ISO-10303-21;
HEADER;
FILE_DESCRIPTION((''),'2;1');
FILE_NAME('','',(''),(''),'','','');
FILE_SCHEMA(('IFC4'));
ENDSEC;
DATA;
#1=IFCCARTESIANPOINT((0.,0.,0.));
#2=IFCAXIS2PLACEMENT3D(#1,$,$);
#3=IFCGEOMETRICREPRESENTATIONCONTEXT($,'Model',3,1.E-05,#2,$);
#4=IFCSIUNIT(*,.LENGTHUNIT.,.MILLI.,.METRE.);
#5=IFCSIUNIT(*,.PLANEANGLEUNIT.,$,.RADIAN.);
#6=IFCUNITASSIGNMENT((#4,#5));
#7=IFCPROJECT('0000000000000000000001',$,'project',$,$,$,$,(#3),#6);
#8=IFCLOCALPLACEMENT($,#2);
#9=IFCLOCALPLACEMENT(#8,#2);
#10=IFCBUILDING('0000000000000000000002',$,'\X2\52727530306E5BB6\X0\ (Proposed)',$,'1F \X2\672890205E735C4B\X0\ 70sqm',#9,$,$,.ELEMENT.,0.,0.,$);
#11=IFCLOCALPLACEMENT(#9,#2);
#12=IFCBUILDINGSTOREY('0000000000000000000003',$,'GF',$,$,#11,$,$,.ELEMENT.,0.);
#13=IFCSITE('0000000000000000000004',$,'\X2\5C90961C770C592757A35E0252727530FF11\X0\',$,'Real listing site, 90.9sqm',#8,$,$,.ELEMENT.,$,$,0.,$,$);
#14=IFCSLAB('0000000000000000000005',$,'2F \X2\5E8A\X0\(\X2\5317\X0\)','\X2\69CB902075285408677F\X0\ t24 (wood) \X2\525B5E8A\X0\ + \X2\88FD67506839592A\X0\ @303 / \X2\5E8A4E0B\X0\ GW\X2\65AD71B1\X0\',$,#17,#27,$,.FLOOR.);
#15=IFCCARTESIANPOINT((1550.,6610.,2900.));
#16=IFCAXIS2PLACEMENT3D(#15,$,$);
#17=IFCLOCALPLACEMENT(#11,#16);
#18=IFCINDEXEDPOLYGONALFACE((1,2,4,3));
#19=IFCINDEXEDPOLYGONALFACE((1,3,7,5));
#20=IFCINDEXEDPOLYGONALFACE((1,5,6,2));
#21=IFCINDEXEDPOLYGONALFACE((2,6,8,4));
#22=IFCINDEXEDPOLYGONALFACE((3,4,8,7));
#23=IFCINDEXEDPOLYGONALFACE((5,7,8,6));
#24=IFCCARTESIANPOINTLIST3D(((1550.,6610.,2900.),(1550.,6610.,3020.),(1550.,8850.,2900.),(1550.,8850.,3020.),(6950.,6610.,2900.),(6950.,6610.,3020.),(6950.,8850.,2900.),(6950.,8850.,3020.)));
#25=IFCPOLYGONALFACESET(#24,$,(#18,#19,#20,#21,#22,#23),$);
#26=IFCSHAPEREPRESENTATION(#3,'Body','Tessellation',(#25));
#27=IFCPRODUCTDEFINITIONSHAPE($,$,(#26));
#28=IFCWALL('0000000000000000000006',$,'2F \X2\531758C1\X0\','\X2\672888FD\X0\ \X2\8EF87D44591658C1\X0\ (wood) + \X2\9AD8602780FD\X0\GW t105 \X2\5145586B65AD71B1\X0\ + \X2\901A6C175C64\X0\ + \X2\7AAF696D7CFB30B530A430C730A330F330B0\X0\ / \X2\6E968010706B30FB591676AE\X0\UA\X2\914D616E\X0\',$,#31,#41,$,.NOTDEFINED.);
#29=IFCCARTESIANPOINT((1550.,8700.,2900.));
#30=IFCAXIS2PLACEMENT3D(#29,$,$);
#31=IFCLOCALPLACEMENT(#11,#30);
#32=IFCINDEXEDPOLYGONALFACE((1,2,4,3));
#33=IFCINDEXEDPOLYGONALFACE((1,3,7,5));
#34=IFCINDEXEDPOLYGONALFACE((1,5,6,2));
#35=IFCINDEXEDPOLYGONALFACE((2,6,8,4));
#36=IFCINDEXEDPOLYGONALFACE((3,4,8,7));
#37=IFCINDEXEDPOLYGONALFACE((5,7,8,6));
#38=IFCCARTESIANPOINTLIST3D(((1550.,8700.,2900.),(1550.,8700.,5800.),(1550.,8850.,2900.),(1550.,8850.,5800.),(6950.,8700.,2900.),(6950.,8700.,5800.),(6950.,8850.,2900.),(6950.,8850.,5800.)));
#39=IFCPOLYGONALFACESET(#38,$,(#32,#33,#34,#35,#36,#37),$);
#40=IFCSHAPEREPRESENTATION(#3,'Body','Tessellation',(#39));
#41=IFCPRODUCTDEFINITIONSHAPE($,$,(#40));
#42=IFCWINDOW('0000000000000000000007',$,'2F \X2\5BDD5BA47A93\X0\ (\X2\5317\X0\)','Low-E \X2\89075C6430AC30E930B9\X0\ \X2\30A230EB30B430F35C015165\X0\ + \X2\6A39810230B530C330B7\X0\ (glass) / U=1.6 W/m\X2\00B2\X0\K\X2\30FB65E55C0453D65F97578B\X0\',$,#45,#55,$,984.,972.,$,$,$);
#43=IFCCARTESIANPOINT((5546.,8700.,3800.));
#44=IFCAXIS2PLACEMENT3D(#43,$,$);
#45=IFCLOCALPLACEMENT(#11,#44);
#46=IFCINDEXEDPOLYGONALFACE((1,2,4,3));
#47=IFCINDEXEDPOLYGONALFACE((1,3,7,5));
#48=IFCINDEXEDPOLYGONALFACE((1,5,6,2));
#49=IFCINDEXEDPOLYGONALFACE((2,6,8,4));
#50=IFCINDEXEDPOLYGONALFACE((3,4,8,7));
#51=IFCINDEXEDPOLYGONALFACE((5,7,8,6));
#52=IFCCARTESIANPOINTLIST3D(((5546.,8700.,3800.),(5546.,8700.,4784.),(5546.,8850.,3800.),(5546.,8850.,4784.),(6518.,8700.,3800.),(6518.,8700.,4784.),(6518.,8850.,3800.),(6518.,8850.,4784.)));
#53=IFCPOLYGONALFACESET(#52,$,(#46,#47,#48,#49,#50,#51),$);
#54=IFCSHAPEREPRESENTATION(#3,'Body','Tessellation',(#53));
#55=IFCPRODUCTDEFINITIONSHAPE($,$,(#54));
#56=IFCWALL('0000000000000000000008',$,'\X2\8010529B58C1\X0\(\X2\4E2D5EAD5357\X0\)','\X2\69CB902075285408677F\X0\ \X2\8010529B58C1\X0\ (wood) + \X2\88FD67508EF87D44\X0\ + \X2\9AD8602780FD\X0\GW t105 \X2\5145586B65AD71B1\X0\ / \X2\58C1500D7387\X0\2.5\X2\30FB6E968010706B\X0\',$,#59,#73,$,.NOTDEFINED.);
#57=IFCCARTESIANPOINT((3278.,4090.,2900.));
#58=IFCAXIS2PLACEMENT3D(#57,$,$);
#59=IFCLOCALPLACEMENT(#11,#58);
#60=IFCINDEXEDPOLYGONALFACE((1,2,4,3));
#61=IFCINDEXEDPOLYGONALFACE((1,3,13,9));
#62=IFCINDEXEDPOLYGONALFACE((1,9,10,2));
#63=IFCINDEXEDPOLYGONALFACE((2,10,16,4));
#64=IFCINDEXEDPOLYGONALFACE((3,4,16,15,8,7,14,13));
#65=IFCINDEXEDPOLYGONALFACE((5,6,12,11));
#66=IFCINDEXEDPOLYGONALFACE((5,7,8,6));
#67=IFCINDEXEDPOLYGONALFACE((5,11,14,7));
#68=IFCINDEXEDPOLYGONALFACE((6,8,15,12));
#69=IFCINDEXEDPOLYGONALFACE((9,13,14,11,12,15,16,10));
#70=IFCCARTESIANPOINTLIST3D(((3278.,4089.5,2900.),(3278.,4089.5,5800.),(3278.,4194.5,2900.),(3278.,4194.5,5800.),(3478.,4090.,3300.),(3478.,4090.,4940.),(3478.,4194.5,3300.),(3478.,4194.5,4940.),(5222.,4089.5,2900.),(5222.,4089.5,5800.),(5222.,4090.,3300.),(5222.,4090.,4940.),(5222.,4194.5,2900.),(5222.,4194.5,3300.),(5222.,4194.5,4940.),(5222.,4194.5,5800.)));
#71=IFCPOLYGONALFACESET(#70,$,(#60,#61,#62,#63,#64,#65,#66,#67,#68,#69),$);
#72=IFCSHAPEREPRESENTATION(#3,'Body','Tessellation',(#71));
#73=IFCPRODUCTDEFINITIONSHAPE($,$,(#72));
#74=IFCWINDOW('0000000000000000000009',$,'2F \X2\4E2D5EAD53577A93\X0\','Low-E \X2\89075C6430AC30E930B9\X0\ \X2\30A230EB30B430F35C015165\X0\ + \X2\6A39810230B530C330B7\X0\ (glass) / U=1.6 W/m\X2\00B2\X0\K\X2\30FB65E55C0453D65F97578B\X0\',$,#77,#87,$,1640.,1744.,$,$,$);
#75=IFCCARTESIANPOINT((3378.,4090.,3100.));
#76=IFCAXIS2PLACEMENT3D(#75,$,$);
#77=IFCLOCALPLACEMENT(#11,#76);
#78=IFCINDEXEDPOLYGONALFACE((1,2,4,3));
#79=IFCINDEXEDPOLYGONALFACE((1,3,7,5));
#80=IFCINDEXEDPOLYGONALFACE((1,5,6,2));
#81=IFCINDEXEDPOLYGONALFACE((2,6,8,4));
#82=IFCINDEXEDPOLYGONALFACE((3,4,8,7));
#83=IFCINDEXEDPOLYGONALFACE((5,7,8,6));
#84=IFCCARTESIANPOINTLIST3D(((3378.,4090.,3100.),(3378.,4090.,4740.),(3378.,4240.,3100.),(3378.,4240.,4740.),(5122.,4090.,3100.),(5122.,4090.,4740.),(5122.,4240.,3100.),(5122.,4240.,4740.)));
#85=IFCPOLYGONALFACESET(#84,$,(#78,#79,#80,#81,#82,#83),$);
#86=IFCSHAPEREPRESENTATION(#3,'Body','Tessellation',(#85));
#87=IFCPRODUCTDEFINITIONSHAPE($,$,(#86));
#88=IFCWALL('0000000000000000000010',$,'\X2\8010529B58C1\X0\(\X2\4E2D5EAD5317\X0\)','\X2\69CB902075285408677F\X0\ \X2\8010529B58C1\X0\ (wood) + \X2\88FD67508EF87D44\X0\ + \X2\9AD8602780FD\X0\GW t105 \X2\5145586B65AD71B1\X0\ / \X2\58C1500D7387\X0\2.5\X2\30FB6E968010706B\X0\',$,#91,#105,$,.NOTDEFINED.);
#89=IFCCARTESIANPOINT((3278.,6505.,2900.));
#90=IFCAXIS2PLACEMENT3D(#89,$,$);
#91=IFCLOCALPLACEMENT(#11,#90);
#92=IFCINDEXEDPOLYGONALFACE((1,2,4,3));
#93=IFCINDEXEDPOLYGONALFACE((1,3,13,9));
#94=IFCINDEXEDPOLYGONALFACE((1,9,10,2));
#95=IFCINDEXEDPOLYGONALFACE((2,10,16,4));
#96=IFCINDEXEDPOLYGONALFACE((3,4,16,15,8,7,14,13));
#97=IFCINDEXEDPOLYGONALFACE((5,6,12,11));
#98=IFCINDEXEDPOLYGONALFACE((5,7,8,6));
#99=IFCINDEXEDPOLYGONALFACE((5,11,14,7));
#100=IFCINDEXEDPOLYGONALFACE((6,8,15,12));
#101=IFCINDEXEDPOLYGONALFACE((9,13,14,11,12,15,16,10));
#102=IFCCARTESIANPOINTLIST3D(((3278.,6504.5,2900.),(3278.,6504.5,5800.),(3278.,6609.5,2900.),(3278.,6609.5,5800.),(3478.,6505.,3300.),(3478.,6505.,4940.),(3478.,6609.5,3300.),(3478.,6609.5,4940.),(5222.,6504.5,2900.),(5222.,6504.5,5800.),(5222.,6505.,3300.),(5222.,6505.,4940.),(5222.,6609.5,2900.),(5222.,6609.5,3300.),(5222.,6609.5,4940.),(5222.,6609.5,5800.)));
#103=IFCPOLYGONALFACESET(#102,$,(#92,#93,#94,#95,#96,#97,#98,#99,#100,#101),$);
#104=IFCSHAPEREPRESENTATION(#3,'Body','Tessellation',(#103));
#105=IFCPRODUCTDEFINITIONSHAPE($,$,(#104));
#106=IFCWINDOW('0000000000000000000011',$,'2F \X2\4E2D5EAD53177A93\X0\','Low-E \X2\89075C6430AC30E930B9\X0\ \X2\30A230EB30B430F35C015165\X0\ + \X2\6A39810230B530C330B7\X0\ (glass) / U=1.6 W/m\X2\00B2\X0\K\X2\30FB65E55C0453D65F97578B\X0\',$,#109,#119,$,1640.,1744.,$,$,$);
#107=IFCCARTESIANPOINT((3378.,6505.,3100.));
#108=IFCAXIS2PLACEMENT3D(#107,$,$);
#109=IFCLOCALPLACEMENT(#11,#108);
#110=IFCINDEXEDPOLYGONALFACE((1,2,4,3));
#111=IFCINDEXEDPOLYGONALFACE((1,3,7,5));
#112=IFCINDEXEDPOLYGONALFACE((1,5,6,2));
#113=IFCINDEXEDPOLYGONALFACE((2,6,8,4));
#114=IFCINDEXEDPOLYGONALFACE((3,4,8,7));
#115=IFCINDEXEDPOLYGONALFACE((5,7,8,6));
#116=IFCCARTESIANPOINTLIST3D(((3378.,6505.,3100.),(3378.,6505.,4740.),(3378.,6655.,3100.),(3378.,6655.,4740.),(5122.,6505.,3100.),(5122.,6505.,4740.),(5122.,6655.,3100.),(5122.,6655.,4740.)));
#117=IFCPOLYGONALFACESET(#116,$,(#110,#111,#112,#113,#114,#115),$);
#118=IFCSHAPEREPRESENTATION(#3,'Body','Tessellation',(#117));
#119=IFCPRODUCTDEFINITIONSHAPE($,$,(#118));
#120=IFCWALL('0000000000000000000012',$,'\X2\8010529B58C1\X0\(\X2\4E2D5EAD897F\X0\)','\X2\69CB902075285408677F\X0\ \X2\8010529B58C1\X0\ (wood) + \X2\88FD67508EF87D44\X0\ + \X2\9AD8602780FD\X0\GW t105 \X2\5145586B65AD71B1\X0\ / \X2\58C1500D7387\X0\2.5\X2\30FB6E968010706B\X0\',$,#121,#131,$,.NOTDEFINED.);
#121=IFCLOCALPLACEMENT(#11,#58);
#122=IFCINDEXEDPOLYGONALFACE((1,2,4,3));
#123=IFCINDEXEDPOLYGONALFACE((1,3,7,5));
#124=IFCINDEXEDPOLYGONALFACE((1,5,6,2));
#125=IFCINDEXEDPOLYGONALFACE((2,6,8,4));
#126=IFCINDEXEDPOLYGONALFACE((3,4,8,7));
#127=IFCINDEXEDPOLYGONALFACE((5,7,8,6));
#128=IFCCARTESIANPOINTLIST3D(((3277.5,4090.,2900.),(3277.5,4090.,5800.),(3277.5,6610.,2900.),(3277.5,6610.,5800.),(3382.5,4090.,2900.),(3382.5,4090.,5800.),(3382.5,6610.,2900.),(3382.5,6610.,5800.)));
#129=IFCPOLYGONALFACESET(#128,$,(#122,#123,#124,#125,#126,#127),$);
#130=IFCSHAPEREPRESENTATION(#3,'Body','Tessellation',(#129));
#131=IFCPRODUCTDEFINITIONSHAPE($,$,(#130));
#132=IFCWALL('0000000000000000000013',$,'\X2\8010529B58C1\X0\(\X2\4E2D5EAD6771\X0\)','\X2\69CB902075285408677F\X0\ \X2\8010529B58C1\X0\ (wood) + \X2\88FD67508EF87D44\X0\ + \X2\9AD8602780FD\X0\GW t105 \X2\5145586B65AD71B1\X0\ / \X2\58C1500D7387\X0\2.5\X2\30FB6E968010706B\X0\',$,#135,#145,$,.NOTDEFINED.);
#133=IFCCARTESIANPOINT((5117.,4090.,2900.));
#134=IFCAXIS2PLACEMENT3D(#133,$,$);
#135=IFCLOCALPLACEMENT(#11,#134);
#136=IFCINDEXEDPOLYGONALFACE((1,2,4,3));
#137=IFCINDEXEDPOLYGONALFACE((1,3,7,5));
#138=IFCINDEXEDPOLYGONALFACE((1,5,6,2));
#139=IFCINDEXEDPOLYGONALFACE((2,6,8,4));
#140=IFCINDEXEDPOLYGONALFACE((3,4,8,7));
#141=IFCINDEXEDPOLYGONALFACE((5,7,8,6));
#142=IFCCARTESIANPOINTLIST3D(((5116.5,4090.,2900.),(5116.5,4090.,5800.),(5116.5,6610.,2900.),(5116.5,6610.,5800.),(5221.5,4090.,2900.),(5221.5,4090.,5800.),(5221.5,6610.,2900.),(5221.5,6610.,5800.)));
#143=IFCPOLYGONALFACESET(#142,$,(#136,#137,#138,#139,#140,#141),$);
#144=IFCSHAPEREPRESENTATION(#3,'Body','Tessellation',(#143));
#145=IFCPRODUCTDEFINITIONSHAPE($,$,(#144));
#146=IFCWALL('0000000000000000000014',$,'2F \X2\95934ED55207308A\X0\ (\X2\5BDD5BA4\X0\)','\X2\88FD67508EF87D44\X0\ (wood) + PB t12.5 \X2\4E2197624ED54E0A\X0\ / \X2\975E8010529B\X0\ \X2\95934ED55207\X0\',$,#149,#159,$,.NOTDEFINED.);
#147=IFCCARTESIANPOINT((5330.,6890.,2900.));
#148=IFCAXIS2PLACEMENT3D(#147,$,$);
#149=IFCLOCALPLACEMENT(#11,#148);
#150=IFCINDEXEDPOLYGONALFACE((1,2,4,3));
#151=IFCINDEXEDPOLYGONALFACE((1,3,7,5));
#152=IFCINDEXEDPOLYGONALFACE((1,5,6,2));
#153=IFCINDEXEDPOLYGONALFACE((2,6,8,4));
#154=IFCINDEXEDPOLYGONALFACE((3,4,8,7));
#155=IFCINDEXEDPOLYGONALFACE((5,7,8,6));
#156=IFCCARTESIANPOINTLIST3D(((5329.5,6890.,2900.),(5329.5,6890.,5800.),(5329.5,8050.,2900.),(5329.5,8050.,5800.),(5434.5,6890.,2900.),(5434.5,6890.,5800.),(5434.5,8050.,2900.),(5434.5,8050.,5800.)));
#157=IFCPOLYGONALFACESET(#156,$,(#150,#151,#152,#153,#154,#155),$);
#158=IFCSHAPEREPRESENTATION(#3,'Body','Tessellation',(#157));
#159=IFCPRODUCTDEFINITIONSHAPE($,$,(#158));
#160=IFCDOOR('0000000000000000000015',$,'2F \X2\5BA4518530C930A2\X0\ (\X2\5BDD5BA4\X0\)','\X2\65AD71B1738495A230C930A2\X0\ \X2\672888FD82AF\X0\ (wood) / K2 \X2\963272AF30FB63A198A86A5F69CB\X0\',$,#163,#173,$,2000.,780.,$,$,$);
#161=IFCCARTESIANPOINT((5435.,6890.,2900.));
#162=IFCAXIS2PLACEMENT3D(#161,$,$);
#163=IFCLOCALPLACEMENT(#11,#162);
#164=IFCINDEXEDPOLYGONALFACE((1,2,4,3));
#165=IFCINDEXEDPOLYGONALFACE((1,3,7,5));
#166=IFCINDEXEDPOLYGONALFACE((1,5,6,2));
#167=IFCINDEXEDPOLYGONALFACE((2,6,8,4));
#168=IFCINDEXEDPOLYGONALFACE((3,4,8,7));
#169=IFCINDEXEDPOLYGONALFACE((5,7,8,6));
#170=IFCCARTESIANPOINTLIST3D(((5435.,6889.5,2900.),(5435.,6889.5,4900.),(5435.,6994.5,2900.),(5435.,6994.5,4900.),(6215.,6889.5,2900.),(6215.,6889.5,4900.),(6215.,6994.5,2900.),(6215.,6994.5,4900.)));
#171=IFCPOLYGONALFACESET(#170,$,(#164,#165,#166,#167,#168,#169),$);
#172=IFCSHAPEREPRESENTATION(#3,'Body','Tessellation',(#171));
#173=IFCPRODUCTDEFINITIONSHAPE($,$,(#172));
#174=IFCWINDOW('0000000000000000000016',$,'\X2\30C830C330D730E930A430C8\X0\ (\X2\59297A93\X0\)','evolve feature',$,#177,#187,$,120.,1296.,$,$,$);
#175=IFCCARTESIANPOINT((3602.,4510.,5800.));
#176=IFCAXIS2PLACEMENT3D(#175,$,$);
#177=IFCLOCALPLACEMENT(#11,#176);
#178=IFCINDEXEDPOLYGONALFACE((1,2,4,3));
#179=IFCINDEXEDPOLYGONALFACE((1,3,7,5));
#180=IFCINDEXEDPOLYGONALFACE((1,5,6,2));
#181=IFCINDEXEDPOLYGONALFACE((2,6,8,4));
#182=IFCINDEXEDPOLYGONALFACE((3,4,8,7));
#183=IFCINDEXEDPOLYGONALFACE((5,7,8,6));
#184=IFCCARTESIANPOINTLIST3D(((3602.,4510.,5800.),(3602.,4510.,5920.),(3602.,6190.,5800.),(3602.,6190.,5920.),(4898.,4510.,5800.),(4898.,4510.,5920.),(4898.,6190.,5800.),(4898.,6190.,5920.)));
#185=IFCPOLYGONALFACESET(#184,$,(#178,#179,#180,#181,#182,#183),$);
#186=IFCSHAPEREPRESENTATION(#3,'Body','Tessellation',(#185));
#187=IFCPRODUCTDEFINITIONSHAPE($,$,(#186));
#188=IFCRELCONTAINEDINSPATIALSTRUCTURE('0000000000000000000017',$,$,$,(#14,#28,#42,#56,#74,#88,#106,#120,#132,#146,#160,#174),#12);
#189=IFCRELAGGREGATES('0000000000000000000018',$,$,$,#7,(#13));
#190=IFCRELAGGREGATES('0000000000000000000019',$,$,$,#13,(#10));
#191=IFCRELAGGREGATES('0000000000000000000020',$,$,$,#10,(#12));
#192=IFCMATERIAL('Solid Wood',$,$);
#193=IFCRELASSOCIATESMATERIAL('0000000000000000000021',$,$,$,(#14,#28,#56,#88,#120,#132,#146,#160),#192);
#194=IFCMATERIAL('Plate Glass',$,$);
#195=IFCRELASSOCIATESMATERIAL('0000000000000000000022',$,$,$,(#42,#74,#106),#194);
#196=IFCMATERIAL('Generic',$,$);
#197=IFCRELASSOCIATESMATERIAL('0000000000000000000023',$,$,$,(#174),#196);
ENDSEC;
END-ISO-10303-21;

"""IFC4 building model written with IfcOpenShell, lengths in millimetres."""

from ifc_helpers import new_model, si_unit, frame, frame_2d, origin, place, context, project, spatial, rectangle, extrude, material, element, fill, save


model = new_model("IFC4")

# Units and contexts
model_context = context("Model", 3, precision=1e-05, world=origin())
ifc_project = project(units=[si_unit("LENGTHUNIT", "METRE", prefix="MILLI"), si_unit("PLANEANGLEUNIT", "RADIAN")], contexts=[model_context])

# Site, building, storey
site_placement = place(None, origin())
site = spatial("IfcSite", under=ifc_project, at=site_placement, Name="岐阜県大垣市割田１", ObjectType="Real listing site, 90.9sqm", CompositionType="ELEMENT", RefElevation=0.0)
building_placement = place(site_placement, origin())
building = spatial("IfcBuilding", under=site, at=building_placement, Name="割田の家 (Proposed)", ObjectType="1F 木造平屋 70sqm", CompositionType="ELEMENT", ElevationOfRefHeight=0.0, ElevationOfTerrain=0.0)
storey_placement = place(building_placement, origin())
storey = spatial("IfcBuildingStorey", under=building, at=storey_placement, Name="GF", CompositionType="ELEMENT", Elevation=0.0)

# Slab
ifc_material_1 = material(Name="Solid Wood")
slab_placement = place(storey_placement, frame((1550.0, 6610.0, 2900.0)))
element("IfcSlab", 1, at=slab_placement, inside=storey, material=ifc_material_1, Name="2F 床(北)", Description="構造用合板 t24 (wood) 剛床 + 製材根太 @303 / 床下 GW断熱", PredefinedType="FLOOR", context=model_context, shape_type="SweptSolid", body=[
    extrude(rectangle(XDim=5400.0, YDim=2240.0, at=frame_2d((2700.0, 1120.0))), frame((1550.0, 6610.0, 2900.0)), (0.0, 0.0, 1.0), 120.0),
])

# Walls, openings, windows
wall_1_placement = place(storey_placement, frame((1550.0, 8700.0, 2900.0)))
wall_1 = element("IfcWall", 2, at=wall_1_placement, inside=storey, material=ifc_material_1, Name="2F 北壁", Description="木製 軸組外壁 (wood) + 高性能GW t105 充填断熱 + 通気層 + 窯業系サイディング / 準耐火・外皮UA配慮", PredefinedType="NOTDEFINED", context=model_context, shape_type="SweptSolid", body=[
    extrude(rectangle(XDim=5400.0, YDim=150.0, at=frame_2d((2700.0, 75.0))), frame((1550.0, 8700.0, 2900.0)), (0.0, 0.0, 1.0), 2900.0),
])
opening_1_placement = place(storey_placement, frame((5546.0, 8700.0, 3800.0)))
opening_1 = element("IfcOpeningElement", 3, at=opening_1_placement, cuts=wall_1, PredefinedType="NOTDEFINED", context=model_context, shape_type="SweptSolid", body=[
    extrude(rectangle(XDim=972.0, YDim=150.0, at=frame_2d((486.0, 75.0))), frame((5546.0, 8700.0, 3800.0)), (0.0, 0.0, 1.0), 984.0),
])
ifc_material_2 = material(Name="Plate Glass")
window_1_placement = place(storey_placement, frame((5546.0, 8700.0, 3800.0)))
window_1 = element("IfcWindow", 4, at=window_1_placement, inside=storey, material=ifc_material_2, Name="2F 寝室窓 (北)", Description="Low-E 複層ガラス アルゴン封入 + 樹脂サッシ (glass) / U=1.6 W/m²K・日射取得型", OverallHeight=984.0, OverallWidth=972.0, context=model_context, shape_type="SweptSolid", body=[
    extrude(rectangle(XDim=972.0, YDim=150.0, at=frame_2d((486.0, 75.0))), frame((5546.0, 8700.0, 3800.0)), (0.0, 0.0, 1.0), 984.0),
])
fill(opening_1, window_1)
wall_2_placement = place(storey_placement, frame((3278.0, 4090.0, 2900.0)))
wall_2 = element("IfcWall", 5, at=wall_2_placement, inside=storey, material=ifc_material_1, Name="耐力壁(中庭南)", Description="構造用合板 耐力壁 (wood) + 製材軸組 + 高性能GW t105 充填断熱 / 壁倍率2.5・準耐火", PredefinedType="NOTDEFINED", context=model_context, shape_type="SweptSolid", body=[
    extrude(rectangle(XDim=1944.0, YDim=105.0, at=frame_2d((972.0, 52.0))), frame((3278.0, 4090.0, 2900.0)), (0.0, 0.0, 1.0), 2900.0),
])
opening_2_placement = place(storey_placement, frame((3378.0, 4090.0, 3100.0)))
opening_2 = element("IfcOpeningElement", 6, at=opening_2_placement, cuts=wall_2, PredefinedType="NOTDEFINED", context=model_context, shape_type="SweptSolid", body=[
    extrude(rectangle(XDim=1744.0, YDim=150.0, at=frame_2d((872.0, 75.0))), frame((3378.0, 4090.0, 3100.0)), (0.0, 0.0, 1.0), 1640.0),
])
window_2_placement = place(storey_placement, frame((3378.0, 4090.0, 3100.0)))
window_2 = element("IfcWindow", 7, at=window_2_placement, inside=storey, material=ifc_material_2, Name="2F 中庭南窓", Description="Low-E 複層ガラス アルゴン封入 + 樹脂サッシ (glass) / U=1.6 W/m²K・日射取得型", OverallHeight=1640.0, OverallWidth=1744.0, context=model_context, shape_type="SweptSolid", body=[
    extrude(rectangle(XDim=1744.0, YDim=150.0, at=frame_2d((872.0, 75.0))), frame((3378.0, 4090.0, 3100.0)), (0.0, 0.0, 1.0), 1640.0),
])
fill(opening_2, window_2)
wall_3_placement = place(storey_placement, frame((3278.0, 6505.0, 2900.0)))
wall_3 = element("IfcWall", 8, at=wall_3_placement, inside=storey, material=ifc_material_1, Name="耐力壁(中庭北)", Description="構造用合板 耐力壁 (wood) + 製材軸組 + 高性能GW t105 充填断熱 / 壁倍率2.5・準耐火", PredefinedType="NOTDEFINED", context=model_context, shape_type="SweptSolid", body=[
    extrude(rectangle(XDim=1944.0, YDim=105.0, at=frame_2d((972.0, 52.0))), frame((3278.0, 6505.0, 2900.0)), (0.0, 0.0, 1.0), 2900.0),
])
opening_3_placement = place(storey_placement, frame((3378.0, 6505.0, 3100.0)))
opening_3 = element("IfcOpeningElement", 9, at=opening_3_placement, cuts=wall_3, PredefinedType="NOTDEFINED", context=model_context, shape_type="SweptSolid", body=[
    extrude(rectangle(XDim=1744.0, YDim=150.0, at=frame_2d((872.0, 75.0))), frame((3378.0, 6505.0, 3100.0)), (0.0, 0.0, 1.0), 1640.0),
])
window_3_placement = place(storey_placement, frame((3378.0, 6505.0, 3100.0)))
window_3 = element("IfcWindow", 10, at=window_3_placement, inside=storey, material=ifc_material_2, Name="2F 中庭北窓", Description="Low-E 複層ガラス アルゴン封入 + 樹脂サッシ (glass) / U=1.6 W/m²K・日射取得型", OverallHeight=1640.0, OverallWidth=1744.0, context=model_context, shape_type="SweptSolid", body=[
    extrude(rectangle(XDim=1744.0, YDim=150.0, at=frame_2d((872.0, 75.0))), frame((3378.0, 6505.0, 3100.0)), (0.0, 0.0, 1.0), 1640.0),
])
fill(opening_3, window_3)

# Walls
wall_4_placement = place(storey_placement, frame((3278.0, 4090.0, 2900.0)))
element("IfcWall", 11, at=wall_4_placement, inside=storey, material=ifc_material_1, Name="耐力壁(中庭西)", Description="構造用合板 耐力壁 (wood) + 製材軸組 + 高性能GW t105 充填断熱 / 壁倍率2.5・準耐火", PredefinedType="NOTDEFINED", context=model_context, shape_type="SweptSolid", body=[
    extrude(rectangle(XDim=105.0, YDim=2520.0, at=frame_2d((52.0, 1260.0))), frame((3278.0, 4090.0, 2900.0)), (0.0, 0.0, 1.0), 2900.0),
])
wall_5_placement = place(storey_placement, frame((5117.0, 4090.0, 2900.0)))
element("IfcWall", 12, at=wall_5_placement, inside=storey, material=ifc_material_1, Name="耐力壁(中庭東)", Description="構造用合板 耐力壁 (wood) + 製材軸組 + 高性能GW t105 充填断熱 / 壁倍率2.5・準耐火", PredefinedType="NOTDEFINED", context=model_context, shape_type="SweptSolid", body=[
    extrude(rectangle(XDim=105.0, YDim=2520.0, at=frame_2d((52.0, 1260.0))), frame((5117.0, 4090.0, 2900.0)), (0.0, 0.0, 1.0), 2900.0),
])
wall_6_placement = place(storey_placement, frame((5330.0, 6890.0, 2900.0)))
element("IfcWall", 13, at=wall_6_placement, inside=storey, material=ifc_material_1, Name="2F 間仕切り (寝室)", Description="製材軸組 (wood) + PB t12.5 両面仕上 / 非耐力 間仕切", PredefinedType="NOTDEFINED", context=model_context, shape_type="SweptSolid", body=[
    extrude(rectangle(XDim=105.0, YDim=1160.0, at=frame_2d((52.0, 580.0))), frame((5330.0, 6890.0, 2900.0)), (0.0, 0.0, 1.0), 2900.0),
])

# Door
door_placement = place(storey_placement, frame((5435.0, 6890.0, 2900.0)))
element("IfcDoor", 14, at=door_placement, inside=storey, material=ifc_material_1, Name="2F 室内ドア (寝室)", Description="断熱玄関ドア 木製芯 (wood) / K2 防犯・採風機構", OverallHeight=2000.0, OverallWidth=780.0, context=model_context, shape_type="SweptSolid", body=[
    extrude(rectangle(XDim=780.0, YDim=105.0, at=frame_2d((390.0, 52.0))), frame((5435.0, 6890.0, 2900.0)), (0.0, 0.0, 1.0), 2000.0),
])

# Window
ifc_material_3 = material(Name="Generic")
window_4_placement = place(storey_placement, frame((3602.0, 4510.0, 5800.0)))
element("IfcWindow", 15, at=window_4_placement, inside=storey, material=ifc_material_3, Name="トップライト (天窓)", Description="evolve feature", OverallHeight=120.0, OverallWidth=1296.0, context=model_context, shape_type="SweptSolid", body=[
    extrude(rectangle(XDim=1296.0, YDim=1680.0, at=frame_2d((648.0, 840.0))), frame((3602.0, 4510.0, 5800.0)), (0.0, 0.0, 1.0), 120.0),
])

save(model, "model.ifc")
